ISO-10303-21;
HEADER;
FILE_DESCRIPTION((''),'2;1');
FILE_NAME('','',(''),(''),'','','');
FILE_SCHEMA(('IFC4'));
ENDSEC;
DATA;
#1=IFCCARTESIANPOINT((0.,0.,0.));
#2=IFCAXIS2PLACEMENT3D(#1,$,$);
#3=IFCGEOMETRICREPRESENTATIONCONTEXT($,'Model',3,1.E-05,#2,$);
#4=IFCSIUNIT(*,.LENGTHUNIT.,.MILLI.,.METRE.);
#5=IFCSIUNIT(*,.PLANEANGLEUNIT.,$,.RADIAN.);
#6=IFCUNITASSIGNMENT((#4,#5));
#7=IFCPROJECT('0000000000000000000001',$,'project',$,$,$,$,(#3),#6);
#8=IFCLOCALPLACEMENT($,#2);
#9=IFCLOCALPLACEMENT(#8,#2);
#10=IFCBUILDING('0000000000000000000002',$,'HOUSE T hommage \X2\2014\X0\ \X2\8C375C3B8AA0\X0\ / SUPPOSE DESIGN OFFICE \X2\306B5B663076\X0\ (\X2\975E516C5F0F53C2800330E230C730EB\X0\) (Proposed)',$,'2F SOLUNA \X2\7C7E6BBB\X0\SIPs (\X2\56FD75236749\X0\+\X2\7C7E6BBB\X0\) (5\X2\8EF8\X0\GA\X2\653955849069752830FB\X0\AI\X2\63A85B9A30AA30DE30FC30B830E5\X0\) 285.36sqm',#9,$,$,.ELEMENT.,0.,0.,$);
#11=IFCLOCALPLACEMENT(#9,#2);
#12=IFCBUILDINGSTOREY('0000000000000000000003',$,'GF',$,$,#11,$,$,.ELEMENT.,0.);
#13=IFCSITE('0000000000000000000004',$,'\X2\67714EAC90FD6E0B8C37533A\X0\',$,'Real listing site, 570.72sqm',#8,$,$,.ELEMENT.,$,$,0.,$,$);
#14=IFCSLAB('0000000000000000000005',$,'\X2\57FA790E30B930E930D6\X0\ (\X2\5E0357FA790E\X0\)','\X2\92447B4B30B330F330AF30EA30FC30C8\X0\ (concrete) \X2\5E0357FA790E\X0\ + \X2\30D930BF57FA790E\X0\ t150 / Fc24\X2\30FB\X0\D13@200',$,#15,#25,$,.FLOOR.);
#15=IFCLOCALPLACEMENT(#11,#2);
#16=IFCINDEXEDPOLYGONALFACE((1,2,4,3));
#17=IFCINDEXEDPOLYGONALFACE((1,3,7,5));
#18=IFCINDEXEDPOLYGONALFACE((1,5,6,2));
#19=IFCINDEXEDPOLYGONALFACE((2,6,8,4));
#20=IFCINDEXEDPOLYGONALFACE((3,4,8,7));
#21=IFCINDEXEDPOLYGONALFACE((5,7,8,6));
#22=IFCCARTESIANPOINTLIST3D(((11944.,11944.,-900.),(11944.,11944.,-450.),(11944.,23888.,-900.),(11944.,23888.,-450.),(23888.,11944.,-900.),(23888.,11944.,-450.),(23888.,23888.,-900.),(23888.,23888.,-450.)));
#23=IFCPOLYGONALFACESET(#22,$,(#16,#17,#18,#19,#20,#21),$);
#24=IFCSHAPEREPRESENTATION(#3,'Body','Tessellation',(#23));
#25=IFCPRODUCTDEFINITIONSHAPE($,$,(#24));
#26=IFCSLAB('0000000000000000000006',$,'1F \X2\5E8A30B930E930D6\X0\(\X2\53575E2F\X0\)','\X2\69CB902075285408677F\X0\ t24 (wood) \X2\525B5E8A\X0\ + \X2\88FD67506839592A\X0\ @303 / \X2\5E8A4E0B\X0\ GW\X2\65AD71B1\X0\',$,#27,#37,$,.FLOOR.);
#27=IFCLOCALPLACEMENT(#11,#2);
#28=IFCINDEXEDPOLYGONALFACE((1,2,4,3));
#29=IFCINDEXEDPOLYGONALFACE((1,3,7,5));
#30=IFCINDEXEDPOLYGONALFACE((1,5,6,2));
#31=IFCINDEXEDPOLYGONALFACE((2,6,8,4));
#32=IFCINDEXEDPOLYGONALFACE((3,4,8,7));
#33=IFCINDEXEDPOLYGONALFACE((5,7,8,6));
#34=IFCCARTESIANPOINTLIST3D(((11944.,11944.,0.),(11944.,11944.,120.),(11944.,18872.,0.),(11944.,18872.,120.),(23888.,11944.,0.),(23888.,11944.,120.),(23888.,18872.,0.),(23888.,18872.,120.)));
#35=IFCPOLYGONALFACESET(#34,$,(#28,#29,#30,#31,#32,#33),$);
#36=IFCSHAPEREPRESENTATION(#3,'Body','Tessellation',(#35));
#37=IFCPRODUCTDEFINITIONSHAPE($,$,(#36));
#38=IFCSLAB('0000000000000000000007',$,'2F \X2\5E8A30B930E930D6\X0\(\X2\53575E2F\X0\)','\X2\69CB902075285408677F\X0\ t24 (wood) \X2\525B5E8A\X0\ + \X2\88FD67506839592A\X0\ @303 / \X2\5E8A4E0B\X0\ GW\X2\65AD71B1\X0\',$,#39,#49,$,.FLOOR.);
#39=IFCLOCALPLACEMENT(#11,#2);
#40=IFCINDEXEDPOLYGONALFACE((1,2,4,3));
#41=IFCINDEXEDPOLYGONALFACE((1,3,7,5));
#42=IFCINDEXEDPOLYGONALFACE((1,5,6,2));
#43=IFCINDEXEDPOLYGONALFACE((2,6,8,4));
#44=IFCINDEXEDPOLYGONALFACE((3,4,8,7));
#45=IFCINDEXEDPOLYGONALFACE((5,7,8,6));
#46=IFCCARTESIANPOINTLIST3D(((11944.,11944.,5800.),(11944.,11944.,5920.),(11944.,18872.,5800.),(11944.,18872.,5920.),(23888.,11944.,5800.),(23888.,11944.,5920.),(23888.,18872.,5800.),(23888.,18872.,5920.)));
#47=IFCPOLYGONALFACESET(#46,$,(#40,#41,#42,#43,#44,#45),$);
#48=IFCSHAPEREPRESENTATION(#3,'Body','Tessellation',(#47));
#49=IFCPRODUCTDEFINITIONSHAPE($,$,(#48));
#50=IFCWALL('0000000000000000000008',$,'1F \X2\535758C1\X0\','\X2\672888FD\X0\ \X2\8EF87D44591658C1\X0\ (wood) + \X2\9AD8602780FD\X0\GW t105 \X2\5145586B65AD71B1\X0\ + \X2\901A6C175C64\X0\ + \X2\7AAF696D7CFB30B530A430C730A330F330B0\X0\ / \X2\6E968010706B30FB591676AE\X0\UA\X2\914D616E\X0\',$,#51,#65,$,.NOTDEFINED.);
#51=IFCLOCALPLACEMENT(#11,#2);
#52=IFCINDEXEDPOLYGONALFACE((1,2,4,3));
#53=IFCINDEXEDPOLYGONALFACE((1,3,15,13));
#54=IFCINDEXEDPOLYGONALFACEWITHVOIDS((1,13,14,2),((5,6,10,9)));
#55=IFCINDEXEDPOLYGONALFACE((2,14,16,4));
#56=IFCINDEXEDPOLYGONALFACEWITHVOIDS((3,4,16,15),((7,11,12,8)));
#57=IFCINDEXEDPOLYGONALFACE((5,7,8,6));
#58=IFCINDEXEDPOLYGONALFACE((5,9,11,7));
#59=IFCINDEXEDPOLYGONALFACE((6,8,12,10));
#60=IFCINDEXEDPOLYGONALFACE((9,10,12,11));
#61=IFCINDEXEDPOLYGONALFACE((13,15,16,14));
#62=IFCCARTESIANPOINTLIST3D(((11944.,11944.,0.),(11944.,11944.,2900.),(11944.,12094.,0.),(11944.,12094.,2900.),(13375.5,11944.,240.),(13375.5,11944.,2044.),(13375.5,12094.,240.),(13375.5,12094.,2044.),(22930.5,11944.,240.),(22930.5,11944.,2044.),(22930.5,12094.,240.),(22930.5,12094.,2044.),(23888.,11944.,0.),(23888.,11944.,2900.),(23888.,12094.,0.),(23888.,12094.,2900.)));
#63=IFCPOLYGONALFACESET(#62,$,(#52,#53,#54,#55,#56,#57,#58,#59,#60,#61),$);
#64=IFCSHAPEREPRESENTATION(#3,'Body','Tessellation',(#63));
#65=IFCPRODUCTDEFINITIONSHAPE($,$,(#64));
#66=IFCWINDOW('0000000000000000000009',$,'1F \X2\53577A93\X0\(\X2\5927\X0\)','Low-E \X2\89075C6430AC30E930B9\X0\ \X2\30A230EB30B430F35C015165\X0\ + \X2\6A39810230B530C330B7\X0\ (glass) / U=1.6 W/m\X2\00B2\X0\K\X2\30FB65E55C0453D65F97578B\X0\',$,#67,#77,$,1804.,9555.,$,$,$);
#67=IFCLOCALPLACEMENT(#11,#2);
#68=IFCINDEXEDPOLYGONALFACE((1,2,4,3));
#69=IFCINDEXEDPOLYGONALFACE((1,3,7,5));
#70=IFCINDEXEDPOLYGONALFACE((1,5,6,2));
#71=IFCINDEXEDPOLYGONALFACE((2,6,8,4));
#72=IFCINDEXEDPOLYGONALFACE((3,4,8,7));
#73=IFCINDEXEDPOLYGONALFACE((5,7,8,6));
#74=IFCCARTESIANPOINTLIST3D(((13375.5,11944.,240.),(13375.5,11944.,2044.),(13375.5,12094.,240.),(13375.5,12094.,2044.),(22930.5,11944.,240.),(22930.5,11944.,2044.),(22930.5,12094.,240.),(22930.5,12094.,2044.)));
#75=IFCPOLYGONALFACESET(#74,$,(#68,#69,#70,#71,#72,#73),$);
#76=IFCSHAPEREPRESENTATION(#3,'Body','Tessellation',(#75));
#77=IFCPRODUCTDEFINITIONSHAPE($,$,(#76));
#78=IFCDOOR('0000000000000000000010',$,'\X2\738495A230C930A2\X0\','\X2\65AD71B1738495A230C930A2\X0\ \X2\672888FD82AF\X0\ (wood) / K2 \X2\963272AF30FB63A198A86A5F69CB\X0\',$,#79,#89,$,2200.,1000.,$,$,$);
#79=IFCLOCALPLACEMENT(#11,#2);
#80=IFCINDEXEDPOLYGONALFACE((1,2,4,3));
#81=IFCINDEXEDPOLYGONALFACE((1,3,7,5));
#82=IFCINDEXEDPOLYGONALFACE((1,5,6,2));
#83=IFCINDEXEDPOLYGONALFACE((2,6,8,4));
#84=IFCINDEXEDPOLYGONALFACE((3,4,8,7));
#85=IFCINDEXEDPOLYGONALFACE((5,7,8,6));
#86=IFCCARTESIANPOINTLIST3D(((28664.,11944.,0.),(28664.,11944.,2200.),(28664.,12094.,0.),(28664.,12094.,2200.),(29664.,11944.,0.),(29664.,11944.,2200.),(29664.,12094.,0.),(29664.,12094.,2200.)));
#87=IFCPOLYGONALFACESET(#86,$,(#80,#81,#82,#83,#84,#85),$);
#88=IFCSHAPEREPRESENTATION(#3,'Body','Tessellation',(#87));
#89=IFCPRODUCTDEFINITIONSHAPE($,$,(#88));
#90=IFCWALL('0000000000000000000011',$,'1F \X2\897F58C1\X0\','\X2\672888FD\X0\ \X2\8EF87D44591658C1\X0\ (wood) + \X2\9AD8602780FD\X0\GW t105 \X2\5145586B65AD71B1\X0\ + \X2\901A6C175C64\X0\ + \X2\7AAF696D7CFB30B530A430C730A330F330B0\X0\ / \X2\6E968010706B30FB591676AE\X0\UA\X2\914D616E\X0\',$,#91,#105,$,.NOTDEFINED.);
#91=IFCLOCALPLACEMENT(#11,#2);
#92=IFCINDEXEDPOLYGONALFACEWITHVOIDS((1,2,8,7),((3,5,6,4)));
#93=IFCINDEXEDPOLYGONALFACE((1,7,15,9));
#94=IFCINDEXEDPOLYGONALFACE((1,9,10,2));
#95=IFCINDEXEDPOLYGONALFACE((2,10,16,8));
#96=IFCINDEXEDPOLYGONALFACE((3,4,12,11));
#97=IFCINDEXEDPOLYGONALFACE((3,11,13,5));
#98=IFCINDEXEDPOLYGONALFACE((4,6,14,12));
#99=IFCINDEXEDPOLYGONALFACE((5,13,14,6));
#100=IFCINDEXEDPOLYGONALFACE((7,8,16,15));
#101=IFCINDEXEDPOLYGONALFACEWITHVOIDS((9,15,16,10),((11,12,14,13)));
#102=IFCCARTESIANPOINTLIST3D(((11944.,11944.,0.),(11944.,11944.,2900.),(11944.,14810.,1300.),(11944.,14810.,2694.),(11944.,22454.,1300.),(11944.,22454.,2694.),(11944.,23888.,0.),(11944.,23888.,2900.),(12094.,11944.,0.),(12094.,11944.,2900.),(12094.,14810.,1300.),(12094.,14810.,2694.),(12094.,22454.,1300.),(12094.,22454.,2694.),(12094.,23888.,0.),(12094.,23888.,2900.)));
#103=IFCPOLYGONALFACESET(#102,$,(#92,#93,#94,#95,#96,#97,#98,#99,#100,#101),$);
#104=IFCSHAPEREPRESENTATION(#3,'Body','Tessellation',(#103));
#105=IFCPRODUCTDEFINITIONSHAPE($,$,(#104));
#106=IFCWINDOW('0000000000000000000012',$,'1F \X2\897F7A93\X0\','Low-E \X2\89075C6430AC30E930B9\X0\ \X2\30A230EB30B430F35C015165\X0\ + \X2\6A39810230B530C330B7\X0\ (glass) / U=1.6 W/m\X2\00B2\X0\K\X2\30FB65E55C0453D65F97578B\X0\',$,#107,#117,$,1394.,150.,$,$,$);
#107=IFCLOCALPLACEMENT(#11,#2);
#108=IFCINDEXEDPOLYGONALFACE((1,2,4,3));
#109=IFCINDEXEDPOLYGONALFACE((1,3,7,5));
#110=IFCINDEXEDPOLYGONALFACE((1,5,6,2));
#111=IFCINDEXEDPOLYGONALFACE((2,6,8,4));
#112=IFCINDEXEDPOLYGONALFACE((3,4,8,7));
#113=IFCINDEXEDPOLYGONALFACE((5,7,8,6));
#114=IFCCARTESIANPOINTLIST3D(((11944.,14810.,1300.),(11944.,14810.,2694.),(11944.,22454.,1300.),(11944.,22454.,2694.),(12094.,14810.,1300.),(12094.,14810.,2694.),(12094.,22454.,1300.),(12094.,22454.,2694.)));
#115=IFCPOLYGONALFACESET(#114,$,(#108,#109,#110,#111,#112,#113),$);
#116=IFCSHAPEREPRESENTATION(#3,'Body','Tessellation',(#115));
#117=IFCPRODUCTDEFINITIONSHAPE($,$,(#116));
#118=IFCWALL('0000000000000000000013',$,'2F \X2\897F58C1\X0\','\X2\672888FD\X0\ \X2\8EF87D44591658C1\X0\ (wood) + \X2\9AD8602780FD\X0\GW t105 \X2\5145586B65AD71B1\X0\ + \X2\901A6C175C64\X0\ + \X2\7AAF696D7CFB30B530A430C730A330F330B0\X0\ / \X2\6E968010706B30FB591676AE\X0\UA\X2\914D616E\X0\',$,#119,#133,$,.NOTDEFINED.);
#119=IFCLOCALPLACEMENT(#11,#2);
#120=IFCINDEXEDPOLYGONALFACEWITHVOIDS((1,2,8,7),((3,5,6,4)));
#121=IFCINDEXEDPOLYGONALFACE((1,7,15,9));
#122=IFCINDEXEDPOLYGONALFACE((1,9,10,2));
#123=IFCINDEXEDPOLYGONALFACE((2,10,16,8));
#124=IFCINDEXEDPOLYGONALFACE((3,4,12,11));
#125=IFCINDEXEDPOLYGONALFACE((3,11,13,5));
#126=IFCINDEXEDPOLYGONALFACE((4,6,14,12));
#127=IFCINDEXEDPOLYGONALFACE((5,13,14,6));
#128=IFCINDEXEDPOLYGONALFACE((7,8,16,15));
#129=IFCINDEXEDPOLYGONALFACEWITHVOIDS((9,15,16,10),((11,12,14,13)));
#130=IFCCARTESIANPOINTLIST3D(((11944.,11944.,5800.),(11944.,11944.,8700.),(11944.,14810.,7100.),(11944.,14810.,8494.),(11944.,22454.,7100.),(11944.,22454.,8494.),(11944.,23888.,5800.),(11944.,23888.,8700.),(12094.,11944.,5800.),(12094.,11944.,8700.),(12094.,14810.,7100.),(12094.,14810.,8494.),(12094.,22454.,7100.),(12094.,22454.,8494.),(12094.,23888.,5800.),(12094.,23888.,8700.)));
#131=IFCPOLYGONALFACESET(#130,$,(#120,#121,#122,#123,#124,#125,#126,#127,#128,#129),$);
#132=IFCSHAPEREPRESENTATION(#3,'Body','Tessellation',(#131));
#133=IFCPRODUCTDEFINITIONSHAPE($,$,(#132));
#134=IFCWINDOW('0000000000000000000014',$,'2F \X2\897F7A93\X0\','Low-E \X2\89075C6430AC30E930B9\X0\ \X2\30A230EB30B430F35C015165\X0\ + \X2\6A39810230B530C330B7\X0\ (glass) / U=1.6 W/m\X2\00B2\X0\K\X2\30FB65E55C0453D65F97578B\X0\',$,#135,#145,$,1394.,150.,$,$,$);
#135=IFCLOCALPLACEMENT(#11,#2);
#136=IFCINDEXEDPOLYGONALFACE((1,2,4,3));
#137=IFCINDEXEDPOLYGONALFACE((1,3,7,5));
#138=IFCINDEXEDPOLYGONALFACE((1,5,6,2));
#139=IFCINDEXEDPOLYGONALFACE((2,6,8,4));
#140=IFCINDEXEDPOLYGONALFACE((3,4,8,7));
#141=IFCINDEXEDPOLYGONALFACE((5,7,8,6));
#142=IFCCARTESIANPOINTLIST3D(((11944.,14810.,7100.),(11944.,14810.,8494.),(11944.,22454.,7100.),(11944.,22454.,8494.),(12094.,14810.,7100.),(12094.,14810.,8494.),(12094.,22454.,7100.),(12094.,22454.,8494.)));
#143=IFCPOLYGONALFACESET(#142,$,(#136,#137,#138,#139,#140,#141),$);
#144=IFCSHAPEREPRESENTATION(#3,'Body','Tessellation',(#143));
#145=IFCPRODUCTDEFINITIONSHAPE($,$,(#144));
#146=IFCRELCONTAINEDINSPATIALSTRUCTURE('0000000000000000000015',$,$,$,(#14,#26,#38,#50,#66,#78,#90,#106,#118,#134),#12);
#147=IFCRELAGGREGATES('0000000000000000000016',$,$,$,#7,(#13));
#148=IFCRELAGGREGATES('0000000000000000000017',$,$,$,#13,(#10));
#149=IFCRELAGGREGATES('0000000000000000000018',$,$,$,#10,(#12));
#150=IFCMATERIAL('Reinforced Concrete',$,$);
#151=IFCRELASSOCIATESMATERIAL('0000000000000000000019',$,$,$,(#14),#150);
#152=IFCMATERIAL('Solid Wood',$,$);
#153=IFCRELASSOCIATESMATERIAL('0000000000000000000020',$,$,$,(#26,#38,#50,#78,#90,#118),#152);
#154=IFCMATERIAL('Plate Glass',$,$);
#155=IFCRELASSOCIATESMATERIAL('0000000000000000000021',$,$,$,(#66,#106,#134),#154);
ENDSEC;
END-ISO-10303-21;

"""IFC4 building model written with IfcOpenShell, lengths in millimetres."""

from ifc_helpers import new_model, si_unit, frame, frame_2d, origin, place, context, project, spatial, rectangle, extrude, material, element, fill, save


model = new_model("IFC4")

# Units and contexts
model_context = context("Model", 3, precision=1e-05, world=origin())
ifc_project = project(units=[si_unit("LENGTHUNIT", "METRE", prefix="MILLI"), si_unit("PLANEANGLEUNIT", "RADIAN")], contexts=[model_context])

# Site, building, storey
site_placement = place(None, origin())
site = spatial("IfcSite", under=ifc_project, at=site_placement, Name="東京都渋谷区", ObjectType="Real listing site, 570.72sqm", CompositionType="ELEMENT", RefElevation=0.0)
building_placement = place(site_placement, origin())
building = spatial("IfcBuilding", under=site, at=building_placement, Name="HOUSE T hommage — 谷尻誠 / SUPPOSE DESIGN OFFICE に学ぶ (非公式参考モデル) (Proposed)", ObjectType="2F SOLUNA 籾殻SIPs (国産杉+籾殻) (5軸GA改善適用・AI推定オマージュ) 285.36sqm", CompositionType="ELEMENT", ElevationOfRefHeight=0.0, ElevationOfTerrain=0.0)
storey_placement = place(building_placement, origin())
storey = spatial("IfcBuildingStorey", under=building, at=storey_placement, Name="GF", CompositionType="ELEMENT", Elevation=0.0)

# Slabs
ifc_material_1 = material(Name="Reinforced Concrete")
slab_1_placement = place(storey_placement, frame((5972.0, 5972.0, -450.0)))
element("IfcSlab", 1, at=slab_1_placement, inside=storey, material=ifc_material_1, Name="基礎スラブ (布基礎)", Description="鉄筋コンクリート (concrete) 布基礎 + ベタ基礎 t150 / Fc24・D13@200", PredefinedType="FLOOR", context=model_context, shape_type="SweptSolid", body=[
    extrude(rectangle(XDim=11944.0, YDim=11944.0, at=frame_2d((5972.0, 5972.0))), frame((5972.0, 5972.0, -450.0)), (0.0, 0.0, 1.0), 450.0),
])
ifc_material_2 = material(Name="Solid Wood")
slab_2_placement = place(storey_placement, frame((5972.0, 5972.0, 0.0)))
element("IfcSlab", 2, at=slab_2_placement, inside=storey, material=ifc_material_2, Name="1F 床スラブ(南帯)", Description="構造用合板 t24 (wood) 剛床 + 製材根太 @303 / 床下 GW断熱", PredefinedType="FLOOR", context=model_context, shape_type="SweptSolid", body=[
    extrude(rectangle(XDim=11944.0, YDim=6928.0, at=frame_2d((5972.0, 3464.0))), frame((5972.0, 5972.0, 0.0)), (0.0, 0.0, 1.0), 120.0),
])
slab_3_placement = place(storey_placement, frame((5972.0, 5972.0, 2900.0)))
element("IfcSlab", 3, at=slab_3_placement, inside=storey, material=ifc_material_2, Name="2F 床スラブ(南帯)", Description="構造用合板 t24 (wood) 剛床 + 製材根太 @303 / 床下 GW断熱", PredefinedType="FLOOR", context=model_context, shape_type="SweptSolid", body=[
    extrude(rectangle(XDim=11944.0, YDim=6928.0, at=frame_2d((5972.0, 3464.0))), frame((5972.0, 5972.0, 2900.0)), (0.0, 0.0, 1.0), 120.0),
])

# Wall, openings, window, door
wall_1_placement = place(storey_placement, frame((5972.0, 5972.0, 0.0)))
wall_1 = element("IfcWall", 4, at=wall_1_placement, inside=storey, material=ifc_material_2, Name="1F 南壁", Description="木製 軸組外壁 (wood) + 高性能GW t105 充填断熱 + 通気層 + 窯業系サイディング / 準耐火・外皮UA配慮", PredefinedType="NOTDEFINED", context=model_context, shape_type="SweptSolid", body=[
    extrude(rectangle(XDim=11944.0, YDim=150.0, at=frame_2d((5972.0, 75.0))), frame((5972.0, 5972.0, 0.0)), (0.0, 0.0, 1.0), 2900.0),
])
opening_1_placement = place(storey_placement, frame((6688.0, 5972.0, 120.0)))
opening_1 = element("IfcOpeningElement", 5, at=opening_1_placement, cuts=wall_1, PredefinedType="NOTDEFINED", context=model_context, shape_type="SweptSolid", body=[
    extrude(rectangle(XDim=9555.0, YDim=150.0, at=frame_2d((4777.0, 75.0))), frame((6688.0, 5972.0, 120.0)), (0.0, 0.0, 1.0), 1804.0),
])
opening_2_placement = place(storey_placement, frame((14332.0, 5972.0, 0.0)))
opening_2 = element("IfcOpeningElement", 6, at=opening_2_placement, cuts=wall_1, PredefinedType="NOTDEFINED", context=model_context, shape_type="SweptSolid", body=[
    extrude(rectangle(XDim=1000.0, YDim=150.0, at=frame_2d((500.0, 75.0))), frame((14332.0, 5972.0, 0.0)), (0.0, 0.0, 1.0), 2200.0),
])
ifc_material_3 = material(Name="Plate Glass")
window_1_placement = place(storey_placement, frame((6688.0, 5972.0, 120.0)))
window_1 = element("IfcWindow", 7, at=window_1_placement, inside=storey, material=ifc_material_3, Name="1F 南窓(大)", Description="Low-E 複層ガラス アルゴン封入 + 樹脂サッシ (glass) / U=1.6 W/m²K・日射取得型", OverallHeight=1804.0, OverallWidth=9555.0, context=model_context, shape_type="SweptSolid", body=[
    extrude(rectangle(XDim=9555.0, YDim=150.0, at=frame_2d((4777.0, 75.0))), frame((6688.0, 5972.0, 120.0)), (0.0, 0.0, 1.0), 1804.0),
])
fill(opening_1, window_1)
door_placement = place(storey_placement, frame((14332.0, 5972.0, 0.0)))
door = element("IfcDoor", 8, at=door_placement, inside=storey, material=ifc_material_2, Name="玄関ドア", Description="断熱玄関ドア 木製芯 (wood) / K2 防犯・採風機構", OverallHeight=2200.0, OverallWidth=1000.0, context=model_context, shape_type="SweptSolid", body=[
    extrude(rectangle(XDim=1000.0, YDim=150.0, at=frame_2d((500.0, 75.0))), frame((14332.0, 5972.0, 0.0)), (0.0, 0.0, 1.0), 2200.0),
])
fill(opening_2, door)

# Wall, opening, window
wall_2_placement = place(storey_placement, frame((5972.0, 5972.0, 0.0)))
wall_2 = element("IfcWall", 9, at=wall_2_placement, inside=storey, material=ifc_material_2, Name="1F 西壁", Description="木製 軸組外壁 (wood) + 高性能GW t105 充填断熱 + 通気層 + 窯業系サイディング / 準耐火・外皮UA配慮", PredefinedType="NOTDEFINED", context=model_context, shape_type="SweptSolid", body=[
    extrude(rectangle(XDim=150.0, YDim=11944.0, at=frame_2d((75.0, 5972.0))), frame((5972.0, 5972.0, 0.0)), (0.0, 0.0, 1.0), 2900.0),
])
opening_3_placement = place(storey_placement, frame((5972.0, 7405.0, 650.0)))
opening_3 = element("IfcOpeningElement", 10, at=opening_3_placement, cuts=wall_2, PredefinedType="NOTDEFINED", context=model_context, shape_type="SweptSolid", body=[
    extrude(rectangle(XDim=150.0, YDim=7644.0, at=frame_2d((75.0, 3822.0))), frame((5972.0, 7405.0, 650.0)), (0.0, 0.0, 1.0), 1394.0),
])
window_2_placement = place(storey_placement, frame((5972.0, 7405.0, 650.0)))
window_2 = element("IfcWindow", 11, at=window_2_placement, inside=storey, material=ifc_material_3, Name="1F 西窓", Description="Low-E 複層ガラス アルゴン封入 + 樹脂サッシ (glass) / U=1.6 W/m²K・日射取得型", OverallHeight=1394.0, OverallWidth=150.0, context=model_context, shape_type="SweptSolid", body=[
    extrude(rectangle(XDim=150.0, YDim=7644.0, at=frame_2d((75.0, 3822.0))), frame((5972.0, 7405.0, 650.0)), (0.0, 0.0, 1.0), 1394.0),
])
fill(opening_3, window_2)

# Wall, opening, window
wall_3_placement = place(storey_placement, frame((5972.0, 5972.0, 2900.0)))
wall_3 = element("IfcWall", 12, at=wall_3_placement, inside=storey, material=ifc_material_2, Name="2F 西壁", Description="木製 軸組外壁 (wood) + 高性能GW t105 充填断熱 + 通気層 + 窯業系サイディング / 準耐火・外皮UA配慮", PredefinedType="NOTDEFINED", context=model_context, shape_type="SweptSolid", body=[
    extrude(rectangle(XDim=150.0, YDim=11944.0, at=frame_2d((75.0, 5972.0))), frame((5972.0, 5972.0, 2900.0)), (0.0, 0.0, 1.0), 2900.0),
])
opening_4_placement = place(storey_placement, frame((5972.0, 7405.0, 3550.0)))
opening_4 = element("IfcOpeningElement", 13, at=opening_4_placement, cuts=wall_3, PredefinedType="NOTDEFINED", context=model_context, shape_type="SweptSolid", body=[
    extrude(rectangle(XDim=150.0, YDim=7644.0, at=frame_2d((75.0, 3822.0))), frame((5972.0, 7405.0, 3550.0)), (0.0, 0.0, 1.0), 1394.0),
])
window_3_placement = place(storey_placement, frame((5972.0, 7405.0, 3550.0)))
window_3 = element("IfcWindow", 14, at=window_3_placement, inside=storey, material=ifc_material_3, Name="2F 西窓", Description="Low-E 複層ガラス アルゴン封入 + 樹脂サッシ (glass) / U=1.6 W/m²K・日射取得型", OverallHeight=1394.0, OverallWidth=150.0, context=model_context, shape_type="SweptSolid", body=[
    extrude(rectangle(XDim=150.0, YDim=7644.0, at=frame_2d((75.0, 3822.0))), frame((5972.0, 7405.0, 3550.0)), (0.0, 0.0, 1.0), 1394.0),
])
fill(opening_4, window_3)

save(model, "model.ifc")
